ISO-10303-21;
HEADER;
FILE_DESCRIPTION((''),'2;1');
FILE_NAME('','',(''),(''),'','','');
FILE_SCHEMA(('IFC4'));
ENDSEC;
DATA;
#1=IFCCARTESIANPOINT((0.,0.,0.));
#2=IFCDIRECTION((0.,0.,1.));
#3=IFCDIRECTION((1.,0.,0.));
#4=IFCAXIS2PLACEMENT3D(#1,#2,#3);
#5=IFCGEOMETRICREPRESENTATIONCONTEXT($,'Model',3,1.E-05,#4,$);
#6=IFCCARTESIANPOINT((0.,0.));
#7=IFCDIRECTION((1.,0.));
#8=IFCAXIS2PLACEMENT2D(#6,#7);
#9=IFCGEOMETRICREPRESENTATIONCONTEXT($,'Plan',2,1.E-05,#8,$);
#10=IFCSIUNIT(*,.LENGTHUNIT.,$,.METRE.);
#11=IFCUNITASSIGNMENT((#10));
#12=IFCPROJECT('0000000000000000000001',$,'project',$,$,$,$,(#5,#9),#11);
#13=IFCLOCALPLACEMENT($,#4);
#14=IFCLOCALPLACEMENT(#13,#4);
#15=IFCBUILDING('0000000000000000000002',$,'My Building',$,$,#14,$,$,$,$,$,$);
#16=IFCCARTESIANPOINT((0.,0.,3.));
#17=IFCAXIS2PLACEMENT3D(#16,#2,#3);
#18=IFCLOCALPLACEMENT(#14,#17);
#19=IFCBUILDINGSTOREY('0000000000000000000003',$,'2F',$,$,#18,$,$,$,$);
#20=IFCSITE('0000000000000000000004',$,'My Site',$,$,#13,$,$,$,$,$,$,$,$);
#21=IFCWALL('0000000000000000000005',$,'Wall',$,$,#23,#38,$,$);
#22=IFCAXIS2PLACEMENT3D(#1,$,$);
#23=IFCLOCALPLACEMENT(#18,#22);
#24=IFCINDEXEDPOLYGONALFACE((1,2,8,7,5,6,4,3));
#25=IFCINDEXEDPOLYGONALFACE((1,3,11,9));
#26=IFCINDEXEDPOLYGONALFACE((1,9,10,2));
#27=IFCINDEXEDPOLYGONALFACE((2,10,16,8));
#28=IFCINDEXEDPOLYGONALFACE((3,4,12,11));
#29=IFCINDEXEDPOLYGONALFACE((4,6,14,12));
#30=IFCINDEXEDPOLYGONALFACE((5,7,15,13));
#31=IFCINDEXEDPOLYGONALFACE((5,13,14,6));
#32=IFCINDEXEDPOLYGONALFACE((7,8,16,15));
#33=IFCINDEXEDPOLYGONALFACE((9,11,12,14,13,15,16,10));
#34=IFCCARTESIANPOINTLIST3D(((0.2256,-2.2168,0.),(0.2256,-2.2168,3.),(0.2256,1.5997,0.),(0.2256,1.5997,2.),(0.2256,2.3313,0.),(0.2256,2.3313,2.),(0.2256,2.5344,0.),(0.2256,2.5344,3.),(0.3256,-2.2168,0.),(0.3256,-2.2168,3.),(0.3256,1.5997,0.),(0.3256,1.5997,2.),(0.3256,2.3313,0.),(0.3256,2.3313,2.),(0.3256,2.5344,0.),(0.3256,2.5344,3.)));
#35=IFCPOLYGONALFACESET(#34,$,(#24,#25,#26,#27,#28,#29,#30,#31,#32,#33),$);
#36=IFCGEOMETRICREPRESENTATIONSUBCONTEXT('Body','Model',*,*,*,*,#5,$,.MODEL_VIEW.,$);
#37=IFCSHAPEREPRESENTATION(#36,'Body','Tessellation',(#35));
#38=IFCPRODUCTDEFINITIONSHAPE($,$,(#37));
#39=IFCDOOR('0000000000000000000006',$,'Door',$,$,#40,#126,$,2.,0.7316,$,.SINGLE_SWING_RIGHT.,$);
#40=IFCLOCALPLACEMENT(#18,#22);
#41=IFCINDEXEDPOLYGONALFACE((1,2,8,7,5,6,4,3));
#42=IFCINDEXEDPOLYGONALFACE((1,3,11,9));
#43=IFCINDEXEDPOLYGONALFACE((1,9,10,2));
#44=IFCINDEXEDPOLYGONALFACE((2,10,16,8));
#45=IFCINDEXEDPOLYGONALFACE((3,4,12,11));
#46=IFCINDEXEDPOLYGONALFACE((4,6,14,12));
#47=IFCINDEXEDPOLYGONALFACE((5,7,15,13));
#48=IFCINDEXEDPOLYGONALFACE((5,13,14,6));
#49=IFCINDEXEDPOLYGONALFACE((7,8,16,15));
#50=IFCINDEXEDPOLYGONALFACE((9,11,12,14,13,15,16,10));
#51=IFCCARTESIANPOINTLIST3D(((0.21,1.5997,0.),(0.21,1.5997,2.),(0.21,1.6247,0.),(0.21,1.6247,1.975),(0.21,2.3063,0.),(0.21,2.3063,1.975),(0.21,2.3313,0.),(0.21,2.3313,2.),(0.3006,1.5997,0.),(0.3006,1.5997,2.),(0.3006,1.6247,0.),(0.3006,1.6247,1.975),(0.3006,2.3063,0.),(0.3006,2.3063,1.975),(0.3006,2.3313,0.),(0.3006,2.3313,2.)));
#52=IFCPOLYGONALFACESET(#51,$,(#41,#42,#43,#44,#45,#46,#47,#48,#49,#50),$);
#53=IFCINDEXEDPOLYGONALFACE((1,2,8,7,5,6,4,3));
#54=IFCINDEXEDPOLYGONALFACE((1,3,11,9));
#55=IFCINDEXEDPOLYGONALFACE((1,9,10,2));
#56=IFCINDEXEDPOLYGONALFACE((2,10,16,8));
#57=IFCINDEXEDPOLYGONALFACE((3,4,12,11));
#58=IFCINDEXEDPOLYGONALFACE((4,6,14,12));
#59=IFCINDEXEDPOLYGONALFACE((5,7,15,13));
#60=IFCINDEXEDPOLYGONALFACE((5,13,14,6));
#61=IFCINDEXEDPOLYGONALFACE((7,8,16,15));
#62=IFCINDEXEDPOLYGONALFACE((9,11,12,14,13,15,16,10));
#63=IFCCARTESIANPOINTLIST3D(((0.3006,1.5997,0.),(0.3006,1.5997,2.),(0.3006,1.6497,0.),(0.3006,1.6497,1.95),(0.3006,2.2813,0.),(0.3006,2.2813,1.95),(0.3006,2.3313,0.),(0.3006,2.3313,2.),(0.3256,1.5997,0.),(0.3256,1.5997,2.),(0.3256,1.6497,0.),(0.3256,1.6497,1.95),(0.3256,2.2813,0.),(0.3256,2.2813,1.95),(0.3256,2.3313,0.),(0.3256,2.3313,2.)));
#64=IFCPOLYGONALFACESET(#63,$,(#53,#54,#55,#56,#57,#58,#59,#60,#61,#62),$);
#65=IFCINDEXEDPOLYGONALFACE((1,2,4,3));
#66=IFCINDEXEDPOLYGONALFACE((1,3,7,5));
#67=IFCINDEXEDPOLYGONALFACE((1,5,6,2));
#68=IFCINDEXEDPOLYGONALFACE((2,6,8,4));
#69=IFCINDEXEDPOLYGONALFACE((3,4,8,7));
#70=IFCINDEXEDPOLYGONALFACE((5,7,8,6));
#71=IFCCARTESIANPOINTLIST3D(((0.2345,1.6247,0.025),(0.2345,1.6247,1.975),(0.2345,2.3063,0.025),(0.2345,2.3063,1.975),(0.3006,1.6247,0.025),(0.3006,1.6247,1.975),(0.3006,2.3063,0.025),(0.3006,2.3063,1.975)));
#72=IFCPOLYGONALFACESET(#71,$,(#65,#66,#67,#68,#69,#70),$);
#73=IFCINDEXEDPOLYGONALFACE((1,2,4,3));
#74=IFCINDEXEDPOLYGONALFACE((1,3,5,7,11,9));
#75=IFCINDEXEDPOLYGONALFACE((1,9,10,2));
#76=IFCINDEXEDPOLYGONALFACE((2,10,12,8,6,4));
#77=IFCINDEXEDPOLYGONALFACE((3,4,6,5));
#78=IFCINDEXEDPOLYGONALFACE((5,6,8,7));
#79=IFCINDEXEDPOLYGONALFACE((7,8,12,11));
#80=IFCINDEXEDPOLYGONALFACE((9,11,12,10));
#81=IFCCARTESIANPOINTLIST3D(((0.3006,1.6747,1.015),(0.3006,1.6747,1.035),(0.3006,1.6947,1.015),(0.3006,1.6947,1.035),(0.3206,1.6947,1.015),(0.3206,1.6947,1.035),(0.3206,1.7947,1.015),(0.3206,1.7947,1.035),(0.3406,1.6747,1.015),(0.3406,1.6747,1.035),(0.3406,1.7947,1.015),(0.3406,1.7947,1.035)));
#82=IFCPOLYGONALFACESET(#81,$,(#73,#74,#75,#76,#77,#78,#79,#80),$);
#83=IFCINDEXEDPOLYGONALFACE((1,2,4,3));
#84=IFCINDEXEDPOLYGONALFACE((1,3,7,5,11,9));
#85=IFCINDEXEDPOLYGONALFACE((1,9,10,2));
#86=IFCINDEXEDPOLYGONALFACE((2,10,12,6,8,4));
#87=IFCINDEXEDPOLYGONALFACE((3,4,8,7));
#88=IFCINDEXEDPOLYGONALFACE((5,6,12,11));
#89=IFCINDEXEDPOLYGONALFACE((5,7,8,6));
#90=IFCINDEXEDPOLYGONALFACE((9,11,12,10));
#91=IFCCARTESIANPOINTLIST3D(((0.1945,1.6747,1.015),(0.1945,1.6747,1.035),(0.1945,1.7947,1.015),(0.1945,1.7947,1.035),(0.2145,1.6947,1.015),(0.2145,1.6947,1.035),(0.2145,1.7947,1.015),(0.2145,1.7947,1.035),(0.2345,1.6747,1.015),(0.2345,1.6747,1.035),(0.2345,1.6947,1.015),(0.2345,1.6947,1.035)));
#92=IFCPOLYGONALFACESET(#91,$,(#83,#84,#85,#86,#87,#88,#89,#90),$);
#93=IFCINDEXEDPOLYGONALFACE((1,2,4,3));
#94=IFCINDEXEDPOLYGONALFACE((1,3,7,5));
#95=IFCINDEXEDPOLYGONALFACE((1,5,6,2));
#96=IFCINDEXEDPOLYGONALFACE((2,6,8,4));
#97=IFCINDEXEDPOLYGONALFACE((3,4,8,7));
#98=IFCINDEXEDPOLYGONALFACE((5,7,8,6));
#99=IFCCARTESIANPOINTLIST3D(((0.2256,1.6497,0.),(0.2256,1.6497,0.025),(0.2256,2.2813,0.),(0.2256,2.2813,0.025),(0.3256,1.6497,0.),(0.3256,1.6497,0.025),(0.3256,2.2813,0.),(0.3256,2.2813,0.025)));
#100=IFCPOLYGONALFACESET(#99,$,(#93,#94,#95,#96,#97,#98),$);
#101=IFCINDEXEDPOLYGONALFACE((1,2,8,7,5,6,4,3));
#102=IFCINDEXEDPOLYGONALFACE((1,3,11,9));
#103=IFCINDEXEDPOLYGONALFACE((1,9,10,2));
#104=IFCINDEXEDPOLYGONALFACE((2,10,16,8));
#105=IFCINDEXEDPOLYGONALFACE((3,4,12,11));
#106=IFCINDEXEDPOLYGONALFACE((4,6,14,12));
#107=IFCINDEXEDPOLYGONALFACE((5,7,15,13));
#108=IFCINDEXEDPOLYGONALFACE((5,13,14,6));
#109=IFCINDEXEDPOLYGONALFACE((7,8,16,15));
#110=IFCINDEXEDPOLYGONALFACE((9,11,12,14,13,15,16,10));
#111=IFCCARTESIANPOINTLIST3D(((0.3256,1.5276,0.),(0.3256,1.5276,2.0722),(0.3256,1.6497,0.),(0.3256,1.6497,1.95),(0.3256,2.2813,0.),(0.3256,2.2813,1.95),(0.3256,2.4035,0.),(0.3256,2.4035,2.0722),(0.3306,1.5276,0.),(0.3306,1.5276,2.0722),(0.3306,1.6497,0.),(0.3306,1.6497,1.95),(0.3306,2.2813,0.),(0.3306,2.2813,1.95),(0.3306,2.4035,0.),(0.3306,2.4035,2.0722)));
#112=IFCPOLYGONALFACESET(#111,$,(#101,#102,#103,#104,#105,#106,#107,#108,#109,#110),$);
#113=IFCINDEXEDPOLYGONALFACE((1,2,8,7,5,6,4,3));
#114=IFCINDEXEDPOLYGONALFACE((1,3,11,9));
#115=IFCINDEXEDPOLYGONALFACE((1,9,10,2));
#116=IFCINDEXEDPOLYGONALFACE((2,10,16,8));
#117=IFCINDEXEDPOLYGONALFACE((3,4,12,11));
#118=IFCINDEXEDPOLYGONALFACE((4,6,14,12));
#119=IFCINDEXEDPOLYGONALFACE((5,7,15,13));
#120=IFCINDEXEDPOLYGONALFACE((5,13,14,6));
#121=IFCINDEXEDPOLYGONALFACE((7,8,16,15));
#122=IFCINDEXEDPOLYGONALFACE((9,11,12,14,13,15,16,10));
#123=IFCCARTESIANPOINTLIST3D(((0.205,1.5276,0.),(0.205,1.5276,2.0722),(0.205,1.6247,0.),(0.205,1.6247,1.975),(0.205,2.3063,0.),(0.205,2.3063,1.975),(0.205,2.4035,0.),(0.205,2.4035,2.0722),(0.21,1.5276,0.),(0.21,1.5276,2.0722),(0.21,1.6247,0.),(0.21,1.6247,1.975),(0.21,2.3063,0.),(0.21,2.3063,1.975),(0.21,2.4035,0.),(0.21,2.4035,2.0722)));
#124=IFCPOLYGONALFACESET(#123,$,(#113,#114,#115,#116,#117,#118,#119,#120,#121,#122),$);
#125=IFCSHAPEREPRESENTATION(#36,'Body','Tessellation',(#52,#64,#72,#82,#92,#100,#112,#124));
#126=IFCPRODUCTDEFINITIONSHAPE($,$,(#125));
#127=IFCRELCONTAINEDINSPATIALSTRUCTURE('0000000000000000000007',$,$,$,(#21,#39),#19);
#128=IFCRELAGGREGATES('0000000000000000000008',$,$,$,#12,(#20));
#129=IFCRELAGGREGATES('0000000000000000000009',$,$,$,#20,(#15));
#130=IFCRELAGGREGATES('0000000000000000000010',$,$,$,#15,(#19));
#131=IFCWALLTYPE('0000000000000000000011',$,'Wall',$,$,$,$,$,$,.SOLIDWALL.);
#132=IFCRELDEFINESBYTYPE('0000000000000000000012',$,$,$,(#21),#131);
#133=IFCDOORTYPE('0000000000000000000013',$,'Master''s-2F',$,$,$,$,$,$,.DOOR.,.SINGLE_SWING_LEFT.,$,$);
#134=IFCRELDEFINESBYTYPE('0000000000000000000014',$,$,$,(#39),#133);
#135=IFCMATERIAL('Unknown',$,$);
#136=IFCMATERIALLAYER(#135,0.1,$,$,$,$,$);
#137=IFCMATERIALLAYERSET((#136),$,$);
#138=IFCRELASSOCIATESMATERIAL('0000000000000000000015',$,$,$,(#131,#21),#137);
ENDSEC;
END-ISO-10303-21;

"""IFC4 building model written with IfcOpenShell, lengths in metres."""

from ifc_helpers import new_model, entity, si_unit, frame, origin_with_axes, origin_2d_with_axis, place, context, subcontext, project, spatial, line, indexed_curve, outline, extrude, shape, source, transform, mapped, material, layer, layer_set, layer_usage, type_object, type_shapes, element, fill, save


model = new_model("IFC4")

# Units and contexts
model_context = context("Model", 3, precision=1e-05, world=origin_with_axes())
plan_context = context("Plan", 2, precision=1e-05, world=origin_2d_with_axis())
body_context_1 = subcontext(model_context, "Body", "Model", "MODEL_VIEW")
body_context_2 = subcontext(plan_context, "Body", "Plan", "PLAN_VIEW")
ifc_project = project(units=[si_unit("LENGTHUNIT", "METRE")], contexts=[model_context, plan_context])

# Site, building, storey
site_placement = place(None, origin_with_axes())
site = spatial("IfcSite", under=ifc_project, at=site_placement, Name="My Site")
building_placement = place(site_placement, origin_with_axes())
building = spatial("IfcBuilding", under=site, at=building_placement, Name="My Building")
storey_placement = place(building_placement, frame((0.0, 0.0, 3.0), z_axis=(0.0, 0.0, 1.0), x_axis=(1.0, 0.0, 0.0)))
storey = spatial("IfcBuildingStorey", under=building, at=storey_placement, Name="2F")

# Shared definitions
ifc_material = material(Name="Unknown")

# Shared definitions
ifc_layer_1 = layer(ifc_material, 0.1)
ifc_layer_set_1 = layer_set([ifc_layer_1])
wall_type = type_object("IfcWallType", Name="Wall", PredefinedType="SOLIDWALL", material=ifc_layer_set_1)

# Wall, opening, door
ifc_layer_usage_1 = layer_usage(ifc_layer_set_1, "AXIS2", "POSITIVE", 0.0)
wall_1_placement = place(storey_placement, frame((0.3256, -2.2168, 0.0), z_axis=(0.0, 0.0, 1.0), x_axis=(0.0, 1.0, 0.0)))
wall_1 = element("IfcWall", 1, at=wall_1_placement, inside=storey, type_object=wall_type, material=ifc_layer_usage_1, Name="Wall", context=body_context_1, shape_type="SweptSolid", body=[
    extrude(outline(indexed_curve([(0.0, 0.0), (0.0, 0.1), (4.7512, 0.1), (4.7512, 0.0)], segments=[line(1, 2, 3, 4, 1)])), origin_with_axes(), (0.0, 0.0, 1.0), 3.0),
])
shared_shape_1 = source(origin_with_axes(), body_context_1, "Body", "SweptSolid", [
    extrude(outline(indexed_curve([(0.0, 0.0), (0.7316, 0.0), (0.7316, 2.0), (0.0, 2.0)], segments=[line(1, 2, 3, 4, 1)])), frame((0.0, -0.6, 0.0), z_axis=(0.0, -1.0, 0.0), x_axis=(1.0, 0.0, 0.0)), (0.0, 0.0, -1.0), 1.2),
])
opening_1_placement = place(wall_1_placement, frame((3.8165, 0.0, 0.0), z_axis=(0.0, 0.0, 1.0), x_axis=(1.0, 0.0, 0.0)))
opening_1 = element("IfcOpeningElement", 2, at=opening_1_placement, cuts=wall_1, PredefinedType="OPENING", context=body_context_1, shape_type="MappedRepresentation", body=[
    mapped(shared_shape_1, transform((0.0, 0.0, 0.0), x_axis=(1.0, 0.0, 0.0), y_axis=(0.0, 1.0, 0.0), z_axis=(0.0, 0.0, 1.0), scale=1.0)),
])
door_type_1 = type_object("IfcDoorType", Name="Master's-2F", OperationType="SINGLE_SWING_LEFT", PredefinedType="DOOR")
shared_shape_2 = source(origin_with_axes(), body_context_1, "Body", "SweptSolid", [
    extrude(outline(indexed_curve([(0.0, 0.0), (0.0, 2.0), (0.7316, 2.0), (0.7316, 0.0), (0.7066, 0.0), (0.7066, 1.975), (0.025, 1.975), (0.025, 0.0)], segments=[line(1, 2, 3, 4, 5, 6, 7, 8, 1)])), frame((0.0, 0.025, 0.0), z_axis=(0.0, -1.0, 0.0), x_axis=(1.0, 0.0, 0.0)), (0.0, 0.0, -1.0), 0.0906),
    extrude(outline(indexed_curve([(0.0, 0.0), (0.0, 2.0), (0.7316, 2.0), (0.7316, 0.0), (0.6816, 0.0), (0.6816, 1.95), (0.05, 1.95), (0.05, 0.0)], segments=[line(1, 2, 3, 4, 5, 6, 7, 8, 1)])), frame((0.0, 0.0, 0.0), z_axis=(0.0, -1.0, 0.0), x_axis=(1.0, 0.0, 0.0)), (0.0, 0.0, -1.0), 0.025),
    extrude(outline(indexed_curve([(0.0, 0.0), (0.6816, 0.0), (0.6816, 0.0661), (0.0, 0.0661)], segments=[line(1, 2, 3, 4, 1)])), frame((0.025, 0.025, 0.025), z_axis=(0.0, 0.0, 1.0), x_axis=(1.0, 0.0, 0.0)), (0.0, 0.0, 1.0), 1.95),
    extrude(outline(indexed_curve([(0.0, 0.0), (0.0, -0.04), (0.12, -0.04), (0.12, -0.02), (0.02, -0.02), (0.02, 0.0)], segments=[line(1, 2, 3, 4, 5, 6, 1)])), frame((0.075, 0.025, 1.015), z_axis=(0.0, 0.0, 1.0), x_axis=(1.0, 0.0, 0.0)), (0.0, 0.0, 1.0), 0.02),
    extrude(outline(indexed_curve([(0.0, 0.0), (0.0, 0.04), (0.12, 0.04), (0.12, 0.02), (0.02, 0.02), (0.02, 0.0)], segments=[line(1, 2, 3, 4, 5, 6, 1)])), frame((0.075, 0.0911, 1.015), z_axis=(0.0, 0.0, 1.0), x_axis=(1.0, 0.0, 0.0)), (0.0, 0.0, 1.0), 0.02),
    extrude(outline(indexed_curve([(0.0, 0.0), (0.6316, 0.0), (0.6316, 0.1), (0.0, 0.1)], segments=[line(1, 2, 3, 4, 1)])), frame((0.05, 0.0, 0.0), z_axis=(0.0, 0.0, 1.0), x_axis=(1.0, 0.0, 0.0)), (0.0, 0.0, 1.0), 0.025),
    extrude(outline(indexed_curve([(0.0, 0.0), (0.0, 2.0722), (0.8759, 2.0722), (0.8759, 0.0), (0.7537, 0.0), (0.7537, 1.95), (0.1222, 1.95), (0.1222, 0.0)], segments=[line(1, 2, 3, 4, 5, 6, 7, 8, 1)])), frame((-0.0722, -0.005, 0.0), z_axis=(0.0, -1.0, 0.0), x_axis=(1.0, 0.0, 0.0)), (0.0, 0.0, -1.0), 0.005),
    extrude(outline(indexed_curve([(0.0, 0.0), (0.0, 2.0722), (0.8759, 2.0722), (0.8759, 0.0), (0.7787, 0.0), (0.7787, 1.975), (0.0972, 1.975), (0.0972, 0.0)], segments=[line(1, 2, 3, 4, 5, 6, 7, 8, 1)])), frame((-0.0722, 0.1156, 0.0), z_axis=(0.0, -1.0, 0.0), x_axis=(1.0, 0.0, 0.0)), (0.0, 0.0, -1.0), 0.005),
])
shared_shape_3 = source(origin_with_axes(), body_context_2, "Body", "Curve2D", [
    entity("IfcIndexedPolyCurve", entity("IfcCartesianPointList2D", [[0.0, 0.0], [0.0, 0.1156], [0.025, 0.1156], [0.025, 0.025], [0.05, 0.025], [0.05, 0.0]]), [entity("IfcLineIndex", [1, 2, 3, 4, 5, 6, 1])]),
    entity("IfcIndexedPolyCurve", entity("IfcCartesianPointList2D", [[0.7316, 0.0], [0.7316, 0.1156], [0.7066, 0.1156], [0.7066, 0.025], [0.6816, 0.025], [0.6816, 0.0]]), [entity("IfcLineIndex", [1, 2, 3, 4, 5, 6, 1])]),
    entity("IfcTrimmedCurve", entity("IfcEllipse", entity("IfcAxis2Placement2D", entity("IfcCartesianPoint", [0.6405, 0.1156]), entity("IfcDirection", [1.0, 0.0])), 0.6155, 0.6816), [entity("IfcCartesianPoint", [0.6405, 0.7972])], [entity("IfcCartesianPoint", [0.025, 0.1156])], True, "CARTESIAN"),
    entity("IfcIndexedPolyCurve", entity("IfcCartesianPointList2D", [[0.7066, 0.1156], [0.6405, 0.1156], [0.6405, 0.7972], [0.7066, 0.7972]]), [entity("IfcLineIndex", [1, 2, 3, 4, 1])]),
])
type_shapes(door_type_1, [shared_shape_2, shared_shape_3])
door_1_placement = place(opening_1_placement, frame((0.0, 0.0, 0.0), z_axis=(0.0, 0.0, 1.0), x_axis=(1.0, 0.0, 0.0)))
door_1 = element("IfcDoor", 3, at=door_1_placement, inside=storey, type_object=door_type_1, Name="Door", OperationType="SINGLE_SWING_RIGHT", OverallHeight=2.0, OverallWidth=0.7316, shapes=[
    shape(body_context_1, "Body", "MappedRepresentation", [mapped(shared_shape_2, transform((0.0, 0.0, 0.0), x_axis=(1.0, 0.0, 0.0), y_axis=(0.0, 1.0, 0.0), z_axis=(0.0, 0.0, 1.0), scale=1.0))]),
    shape(body_context_2, "Body", "MappedRepresentation", [mapped(shared_shape_3, transform((0.0, 0.0, 0.0), x_axis=(1.0, 0.0, 0.0), y_axis=(0.0, 1.0, 0.0), z_axis=(0.0, 0.0, 1.0), scale=1.0))]),
])
fill(opening_1, door_1)

save(model, "model.ifc")
